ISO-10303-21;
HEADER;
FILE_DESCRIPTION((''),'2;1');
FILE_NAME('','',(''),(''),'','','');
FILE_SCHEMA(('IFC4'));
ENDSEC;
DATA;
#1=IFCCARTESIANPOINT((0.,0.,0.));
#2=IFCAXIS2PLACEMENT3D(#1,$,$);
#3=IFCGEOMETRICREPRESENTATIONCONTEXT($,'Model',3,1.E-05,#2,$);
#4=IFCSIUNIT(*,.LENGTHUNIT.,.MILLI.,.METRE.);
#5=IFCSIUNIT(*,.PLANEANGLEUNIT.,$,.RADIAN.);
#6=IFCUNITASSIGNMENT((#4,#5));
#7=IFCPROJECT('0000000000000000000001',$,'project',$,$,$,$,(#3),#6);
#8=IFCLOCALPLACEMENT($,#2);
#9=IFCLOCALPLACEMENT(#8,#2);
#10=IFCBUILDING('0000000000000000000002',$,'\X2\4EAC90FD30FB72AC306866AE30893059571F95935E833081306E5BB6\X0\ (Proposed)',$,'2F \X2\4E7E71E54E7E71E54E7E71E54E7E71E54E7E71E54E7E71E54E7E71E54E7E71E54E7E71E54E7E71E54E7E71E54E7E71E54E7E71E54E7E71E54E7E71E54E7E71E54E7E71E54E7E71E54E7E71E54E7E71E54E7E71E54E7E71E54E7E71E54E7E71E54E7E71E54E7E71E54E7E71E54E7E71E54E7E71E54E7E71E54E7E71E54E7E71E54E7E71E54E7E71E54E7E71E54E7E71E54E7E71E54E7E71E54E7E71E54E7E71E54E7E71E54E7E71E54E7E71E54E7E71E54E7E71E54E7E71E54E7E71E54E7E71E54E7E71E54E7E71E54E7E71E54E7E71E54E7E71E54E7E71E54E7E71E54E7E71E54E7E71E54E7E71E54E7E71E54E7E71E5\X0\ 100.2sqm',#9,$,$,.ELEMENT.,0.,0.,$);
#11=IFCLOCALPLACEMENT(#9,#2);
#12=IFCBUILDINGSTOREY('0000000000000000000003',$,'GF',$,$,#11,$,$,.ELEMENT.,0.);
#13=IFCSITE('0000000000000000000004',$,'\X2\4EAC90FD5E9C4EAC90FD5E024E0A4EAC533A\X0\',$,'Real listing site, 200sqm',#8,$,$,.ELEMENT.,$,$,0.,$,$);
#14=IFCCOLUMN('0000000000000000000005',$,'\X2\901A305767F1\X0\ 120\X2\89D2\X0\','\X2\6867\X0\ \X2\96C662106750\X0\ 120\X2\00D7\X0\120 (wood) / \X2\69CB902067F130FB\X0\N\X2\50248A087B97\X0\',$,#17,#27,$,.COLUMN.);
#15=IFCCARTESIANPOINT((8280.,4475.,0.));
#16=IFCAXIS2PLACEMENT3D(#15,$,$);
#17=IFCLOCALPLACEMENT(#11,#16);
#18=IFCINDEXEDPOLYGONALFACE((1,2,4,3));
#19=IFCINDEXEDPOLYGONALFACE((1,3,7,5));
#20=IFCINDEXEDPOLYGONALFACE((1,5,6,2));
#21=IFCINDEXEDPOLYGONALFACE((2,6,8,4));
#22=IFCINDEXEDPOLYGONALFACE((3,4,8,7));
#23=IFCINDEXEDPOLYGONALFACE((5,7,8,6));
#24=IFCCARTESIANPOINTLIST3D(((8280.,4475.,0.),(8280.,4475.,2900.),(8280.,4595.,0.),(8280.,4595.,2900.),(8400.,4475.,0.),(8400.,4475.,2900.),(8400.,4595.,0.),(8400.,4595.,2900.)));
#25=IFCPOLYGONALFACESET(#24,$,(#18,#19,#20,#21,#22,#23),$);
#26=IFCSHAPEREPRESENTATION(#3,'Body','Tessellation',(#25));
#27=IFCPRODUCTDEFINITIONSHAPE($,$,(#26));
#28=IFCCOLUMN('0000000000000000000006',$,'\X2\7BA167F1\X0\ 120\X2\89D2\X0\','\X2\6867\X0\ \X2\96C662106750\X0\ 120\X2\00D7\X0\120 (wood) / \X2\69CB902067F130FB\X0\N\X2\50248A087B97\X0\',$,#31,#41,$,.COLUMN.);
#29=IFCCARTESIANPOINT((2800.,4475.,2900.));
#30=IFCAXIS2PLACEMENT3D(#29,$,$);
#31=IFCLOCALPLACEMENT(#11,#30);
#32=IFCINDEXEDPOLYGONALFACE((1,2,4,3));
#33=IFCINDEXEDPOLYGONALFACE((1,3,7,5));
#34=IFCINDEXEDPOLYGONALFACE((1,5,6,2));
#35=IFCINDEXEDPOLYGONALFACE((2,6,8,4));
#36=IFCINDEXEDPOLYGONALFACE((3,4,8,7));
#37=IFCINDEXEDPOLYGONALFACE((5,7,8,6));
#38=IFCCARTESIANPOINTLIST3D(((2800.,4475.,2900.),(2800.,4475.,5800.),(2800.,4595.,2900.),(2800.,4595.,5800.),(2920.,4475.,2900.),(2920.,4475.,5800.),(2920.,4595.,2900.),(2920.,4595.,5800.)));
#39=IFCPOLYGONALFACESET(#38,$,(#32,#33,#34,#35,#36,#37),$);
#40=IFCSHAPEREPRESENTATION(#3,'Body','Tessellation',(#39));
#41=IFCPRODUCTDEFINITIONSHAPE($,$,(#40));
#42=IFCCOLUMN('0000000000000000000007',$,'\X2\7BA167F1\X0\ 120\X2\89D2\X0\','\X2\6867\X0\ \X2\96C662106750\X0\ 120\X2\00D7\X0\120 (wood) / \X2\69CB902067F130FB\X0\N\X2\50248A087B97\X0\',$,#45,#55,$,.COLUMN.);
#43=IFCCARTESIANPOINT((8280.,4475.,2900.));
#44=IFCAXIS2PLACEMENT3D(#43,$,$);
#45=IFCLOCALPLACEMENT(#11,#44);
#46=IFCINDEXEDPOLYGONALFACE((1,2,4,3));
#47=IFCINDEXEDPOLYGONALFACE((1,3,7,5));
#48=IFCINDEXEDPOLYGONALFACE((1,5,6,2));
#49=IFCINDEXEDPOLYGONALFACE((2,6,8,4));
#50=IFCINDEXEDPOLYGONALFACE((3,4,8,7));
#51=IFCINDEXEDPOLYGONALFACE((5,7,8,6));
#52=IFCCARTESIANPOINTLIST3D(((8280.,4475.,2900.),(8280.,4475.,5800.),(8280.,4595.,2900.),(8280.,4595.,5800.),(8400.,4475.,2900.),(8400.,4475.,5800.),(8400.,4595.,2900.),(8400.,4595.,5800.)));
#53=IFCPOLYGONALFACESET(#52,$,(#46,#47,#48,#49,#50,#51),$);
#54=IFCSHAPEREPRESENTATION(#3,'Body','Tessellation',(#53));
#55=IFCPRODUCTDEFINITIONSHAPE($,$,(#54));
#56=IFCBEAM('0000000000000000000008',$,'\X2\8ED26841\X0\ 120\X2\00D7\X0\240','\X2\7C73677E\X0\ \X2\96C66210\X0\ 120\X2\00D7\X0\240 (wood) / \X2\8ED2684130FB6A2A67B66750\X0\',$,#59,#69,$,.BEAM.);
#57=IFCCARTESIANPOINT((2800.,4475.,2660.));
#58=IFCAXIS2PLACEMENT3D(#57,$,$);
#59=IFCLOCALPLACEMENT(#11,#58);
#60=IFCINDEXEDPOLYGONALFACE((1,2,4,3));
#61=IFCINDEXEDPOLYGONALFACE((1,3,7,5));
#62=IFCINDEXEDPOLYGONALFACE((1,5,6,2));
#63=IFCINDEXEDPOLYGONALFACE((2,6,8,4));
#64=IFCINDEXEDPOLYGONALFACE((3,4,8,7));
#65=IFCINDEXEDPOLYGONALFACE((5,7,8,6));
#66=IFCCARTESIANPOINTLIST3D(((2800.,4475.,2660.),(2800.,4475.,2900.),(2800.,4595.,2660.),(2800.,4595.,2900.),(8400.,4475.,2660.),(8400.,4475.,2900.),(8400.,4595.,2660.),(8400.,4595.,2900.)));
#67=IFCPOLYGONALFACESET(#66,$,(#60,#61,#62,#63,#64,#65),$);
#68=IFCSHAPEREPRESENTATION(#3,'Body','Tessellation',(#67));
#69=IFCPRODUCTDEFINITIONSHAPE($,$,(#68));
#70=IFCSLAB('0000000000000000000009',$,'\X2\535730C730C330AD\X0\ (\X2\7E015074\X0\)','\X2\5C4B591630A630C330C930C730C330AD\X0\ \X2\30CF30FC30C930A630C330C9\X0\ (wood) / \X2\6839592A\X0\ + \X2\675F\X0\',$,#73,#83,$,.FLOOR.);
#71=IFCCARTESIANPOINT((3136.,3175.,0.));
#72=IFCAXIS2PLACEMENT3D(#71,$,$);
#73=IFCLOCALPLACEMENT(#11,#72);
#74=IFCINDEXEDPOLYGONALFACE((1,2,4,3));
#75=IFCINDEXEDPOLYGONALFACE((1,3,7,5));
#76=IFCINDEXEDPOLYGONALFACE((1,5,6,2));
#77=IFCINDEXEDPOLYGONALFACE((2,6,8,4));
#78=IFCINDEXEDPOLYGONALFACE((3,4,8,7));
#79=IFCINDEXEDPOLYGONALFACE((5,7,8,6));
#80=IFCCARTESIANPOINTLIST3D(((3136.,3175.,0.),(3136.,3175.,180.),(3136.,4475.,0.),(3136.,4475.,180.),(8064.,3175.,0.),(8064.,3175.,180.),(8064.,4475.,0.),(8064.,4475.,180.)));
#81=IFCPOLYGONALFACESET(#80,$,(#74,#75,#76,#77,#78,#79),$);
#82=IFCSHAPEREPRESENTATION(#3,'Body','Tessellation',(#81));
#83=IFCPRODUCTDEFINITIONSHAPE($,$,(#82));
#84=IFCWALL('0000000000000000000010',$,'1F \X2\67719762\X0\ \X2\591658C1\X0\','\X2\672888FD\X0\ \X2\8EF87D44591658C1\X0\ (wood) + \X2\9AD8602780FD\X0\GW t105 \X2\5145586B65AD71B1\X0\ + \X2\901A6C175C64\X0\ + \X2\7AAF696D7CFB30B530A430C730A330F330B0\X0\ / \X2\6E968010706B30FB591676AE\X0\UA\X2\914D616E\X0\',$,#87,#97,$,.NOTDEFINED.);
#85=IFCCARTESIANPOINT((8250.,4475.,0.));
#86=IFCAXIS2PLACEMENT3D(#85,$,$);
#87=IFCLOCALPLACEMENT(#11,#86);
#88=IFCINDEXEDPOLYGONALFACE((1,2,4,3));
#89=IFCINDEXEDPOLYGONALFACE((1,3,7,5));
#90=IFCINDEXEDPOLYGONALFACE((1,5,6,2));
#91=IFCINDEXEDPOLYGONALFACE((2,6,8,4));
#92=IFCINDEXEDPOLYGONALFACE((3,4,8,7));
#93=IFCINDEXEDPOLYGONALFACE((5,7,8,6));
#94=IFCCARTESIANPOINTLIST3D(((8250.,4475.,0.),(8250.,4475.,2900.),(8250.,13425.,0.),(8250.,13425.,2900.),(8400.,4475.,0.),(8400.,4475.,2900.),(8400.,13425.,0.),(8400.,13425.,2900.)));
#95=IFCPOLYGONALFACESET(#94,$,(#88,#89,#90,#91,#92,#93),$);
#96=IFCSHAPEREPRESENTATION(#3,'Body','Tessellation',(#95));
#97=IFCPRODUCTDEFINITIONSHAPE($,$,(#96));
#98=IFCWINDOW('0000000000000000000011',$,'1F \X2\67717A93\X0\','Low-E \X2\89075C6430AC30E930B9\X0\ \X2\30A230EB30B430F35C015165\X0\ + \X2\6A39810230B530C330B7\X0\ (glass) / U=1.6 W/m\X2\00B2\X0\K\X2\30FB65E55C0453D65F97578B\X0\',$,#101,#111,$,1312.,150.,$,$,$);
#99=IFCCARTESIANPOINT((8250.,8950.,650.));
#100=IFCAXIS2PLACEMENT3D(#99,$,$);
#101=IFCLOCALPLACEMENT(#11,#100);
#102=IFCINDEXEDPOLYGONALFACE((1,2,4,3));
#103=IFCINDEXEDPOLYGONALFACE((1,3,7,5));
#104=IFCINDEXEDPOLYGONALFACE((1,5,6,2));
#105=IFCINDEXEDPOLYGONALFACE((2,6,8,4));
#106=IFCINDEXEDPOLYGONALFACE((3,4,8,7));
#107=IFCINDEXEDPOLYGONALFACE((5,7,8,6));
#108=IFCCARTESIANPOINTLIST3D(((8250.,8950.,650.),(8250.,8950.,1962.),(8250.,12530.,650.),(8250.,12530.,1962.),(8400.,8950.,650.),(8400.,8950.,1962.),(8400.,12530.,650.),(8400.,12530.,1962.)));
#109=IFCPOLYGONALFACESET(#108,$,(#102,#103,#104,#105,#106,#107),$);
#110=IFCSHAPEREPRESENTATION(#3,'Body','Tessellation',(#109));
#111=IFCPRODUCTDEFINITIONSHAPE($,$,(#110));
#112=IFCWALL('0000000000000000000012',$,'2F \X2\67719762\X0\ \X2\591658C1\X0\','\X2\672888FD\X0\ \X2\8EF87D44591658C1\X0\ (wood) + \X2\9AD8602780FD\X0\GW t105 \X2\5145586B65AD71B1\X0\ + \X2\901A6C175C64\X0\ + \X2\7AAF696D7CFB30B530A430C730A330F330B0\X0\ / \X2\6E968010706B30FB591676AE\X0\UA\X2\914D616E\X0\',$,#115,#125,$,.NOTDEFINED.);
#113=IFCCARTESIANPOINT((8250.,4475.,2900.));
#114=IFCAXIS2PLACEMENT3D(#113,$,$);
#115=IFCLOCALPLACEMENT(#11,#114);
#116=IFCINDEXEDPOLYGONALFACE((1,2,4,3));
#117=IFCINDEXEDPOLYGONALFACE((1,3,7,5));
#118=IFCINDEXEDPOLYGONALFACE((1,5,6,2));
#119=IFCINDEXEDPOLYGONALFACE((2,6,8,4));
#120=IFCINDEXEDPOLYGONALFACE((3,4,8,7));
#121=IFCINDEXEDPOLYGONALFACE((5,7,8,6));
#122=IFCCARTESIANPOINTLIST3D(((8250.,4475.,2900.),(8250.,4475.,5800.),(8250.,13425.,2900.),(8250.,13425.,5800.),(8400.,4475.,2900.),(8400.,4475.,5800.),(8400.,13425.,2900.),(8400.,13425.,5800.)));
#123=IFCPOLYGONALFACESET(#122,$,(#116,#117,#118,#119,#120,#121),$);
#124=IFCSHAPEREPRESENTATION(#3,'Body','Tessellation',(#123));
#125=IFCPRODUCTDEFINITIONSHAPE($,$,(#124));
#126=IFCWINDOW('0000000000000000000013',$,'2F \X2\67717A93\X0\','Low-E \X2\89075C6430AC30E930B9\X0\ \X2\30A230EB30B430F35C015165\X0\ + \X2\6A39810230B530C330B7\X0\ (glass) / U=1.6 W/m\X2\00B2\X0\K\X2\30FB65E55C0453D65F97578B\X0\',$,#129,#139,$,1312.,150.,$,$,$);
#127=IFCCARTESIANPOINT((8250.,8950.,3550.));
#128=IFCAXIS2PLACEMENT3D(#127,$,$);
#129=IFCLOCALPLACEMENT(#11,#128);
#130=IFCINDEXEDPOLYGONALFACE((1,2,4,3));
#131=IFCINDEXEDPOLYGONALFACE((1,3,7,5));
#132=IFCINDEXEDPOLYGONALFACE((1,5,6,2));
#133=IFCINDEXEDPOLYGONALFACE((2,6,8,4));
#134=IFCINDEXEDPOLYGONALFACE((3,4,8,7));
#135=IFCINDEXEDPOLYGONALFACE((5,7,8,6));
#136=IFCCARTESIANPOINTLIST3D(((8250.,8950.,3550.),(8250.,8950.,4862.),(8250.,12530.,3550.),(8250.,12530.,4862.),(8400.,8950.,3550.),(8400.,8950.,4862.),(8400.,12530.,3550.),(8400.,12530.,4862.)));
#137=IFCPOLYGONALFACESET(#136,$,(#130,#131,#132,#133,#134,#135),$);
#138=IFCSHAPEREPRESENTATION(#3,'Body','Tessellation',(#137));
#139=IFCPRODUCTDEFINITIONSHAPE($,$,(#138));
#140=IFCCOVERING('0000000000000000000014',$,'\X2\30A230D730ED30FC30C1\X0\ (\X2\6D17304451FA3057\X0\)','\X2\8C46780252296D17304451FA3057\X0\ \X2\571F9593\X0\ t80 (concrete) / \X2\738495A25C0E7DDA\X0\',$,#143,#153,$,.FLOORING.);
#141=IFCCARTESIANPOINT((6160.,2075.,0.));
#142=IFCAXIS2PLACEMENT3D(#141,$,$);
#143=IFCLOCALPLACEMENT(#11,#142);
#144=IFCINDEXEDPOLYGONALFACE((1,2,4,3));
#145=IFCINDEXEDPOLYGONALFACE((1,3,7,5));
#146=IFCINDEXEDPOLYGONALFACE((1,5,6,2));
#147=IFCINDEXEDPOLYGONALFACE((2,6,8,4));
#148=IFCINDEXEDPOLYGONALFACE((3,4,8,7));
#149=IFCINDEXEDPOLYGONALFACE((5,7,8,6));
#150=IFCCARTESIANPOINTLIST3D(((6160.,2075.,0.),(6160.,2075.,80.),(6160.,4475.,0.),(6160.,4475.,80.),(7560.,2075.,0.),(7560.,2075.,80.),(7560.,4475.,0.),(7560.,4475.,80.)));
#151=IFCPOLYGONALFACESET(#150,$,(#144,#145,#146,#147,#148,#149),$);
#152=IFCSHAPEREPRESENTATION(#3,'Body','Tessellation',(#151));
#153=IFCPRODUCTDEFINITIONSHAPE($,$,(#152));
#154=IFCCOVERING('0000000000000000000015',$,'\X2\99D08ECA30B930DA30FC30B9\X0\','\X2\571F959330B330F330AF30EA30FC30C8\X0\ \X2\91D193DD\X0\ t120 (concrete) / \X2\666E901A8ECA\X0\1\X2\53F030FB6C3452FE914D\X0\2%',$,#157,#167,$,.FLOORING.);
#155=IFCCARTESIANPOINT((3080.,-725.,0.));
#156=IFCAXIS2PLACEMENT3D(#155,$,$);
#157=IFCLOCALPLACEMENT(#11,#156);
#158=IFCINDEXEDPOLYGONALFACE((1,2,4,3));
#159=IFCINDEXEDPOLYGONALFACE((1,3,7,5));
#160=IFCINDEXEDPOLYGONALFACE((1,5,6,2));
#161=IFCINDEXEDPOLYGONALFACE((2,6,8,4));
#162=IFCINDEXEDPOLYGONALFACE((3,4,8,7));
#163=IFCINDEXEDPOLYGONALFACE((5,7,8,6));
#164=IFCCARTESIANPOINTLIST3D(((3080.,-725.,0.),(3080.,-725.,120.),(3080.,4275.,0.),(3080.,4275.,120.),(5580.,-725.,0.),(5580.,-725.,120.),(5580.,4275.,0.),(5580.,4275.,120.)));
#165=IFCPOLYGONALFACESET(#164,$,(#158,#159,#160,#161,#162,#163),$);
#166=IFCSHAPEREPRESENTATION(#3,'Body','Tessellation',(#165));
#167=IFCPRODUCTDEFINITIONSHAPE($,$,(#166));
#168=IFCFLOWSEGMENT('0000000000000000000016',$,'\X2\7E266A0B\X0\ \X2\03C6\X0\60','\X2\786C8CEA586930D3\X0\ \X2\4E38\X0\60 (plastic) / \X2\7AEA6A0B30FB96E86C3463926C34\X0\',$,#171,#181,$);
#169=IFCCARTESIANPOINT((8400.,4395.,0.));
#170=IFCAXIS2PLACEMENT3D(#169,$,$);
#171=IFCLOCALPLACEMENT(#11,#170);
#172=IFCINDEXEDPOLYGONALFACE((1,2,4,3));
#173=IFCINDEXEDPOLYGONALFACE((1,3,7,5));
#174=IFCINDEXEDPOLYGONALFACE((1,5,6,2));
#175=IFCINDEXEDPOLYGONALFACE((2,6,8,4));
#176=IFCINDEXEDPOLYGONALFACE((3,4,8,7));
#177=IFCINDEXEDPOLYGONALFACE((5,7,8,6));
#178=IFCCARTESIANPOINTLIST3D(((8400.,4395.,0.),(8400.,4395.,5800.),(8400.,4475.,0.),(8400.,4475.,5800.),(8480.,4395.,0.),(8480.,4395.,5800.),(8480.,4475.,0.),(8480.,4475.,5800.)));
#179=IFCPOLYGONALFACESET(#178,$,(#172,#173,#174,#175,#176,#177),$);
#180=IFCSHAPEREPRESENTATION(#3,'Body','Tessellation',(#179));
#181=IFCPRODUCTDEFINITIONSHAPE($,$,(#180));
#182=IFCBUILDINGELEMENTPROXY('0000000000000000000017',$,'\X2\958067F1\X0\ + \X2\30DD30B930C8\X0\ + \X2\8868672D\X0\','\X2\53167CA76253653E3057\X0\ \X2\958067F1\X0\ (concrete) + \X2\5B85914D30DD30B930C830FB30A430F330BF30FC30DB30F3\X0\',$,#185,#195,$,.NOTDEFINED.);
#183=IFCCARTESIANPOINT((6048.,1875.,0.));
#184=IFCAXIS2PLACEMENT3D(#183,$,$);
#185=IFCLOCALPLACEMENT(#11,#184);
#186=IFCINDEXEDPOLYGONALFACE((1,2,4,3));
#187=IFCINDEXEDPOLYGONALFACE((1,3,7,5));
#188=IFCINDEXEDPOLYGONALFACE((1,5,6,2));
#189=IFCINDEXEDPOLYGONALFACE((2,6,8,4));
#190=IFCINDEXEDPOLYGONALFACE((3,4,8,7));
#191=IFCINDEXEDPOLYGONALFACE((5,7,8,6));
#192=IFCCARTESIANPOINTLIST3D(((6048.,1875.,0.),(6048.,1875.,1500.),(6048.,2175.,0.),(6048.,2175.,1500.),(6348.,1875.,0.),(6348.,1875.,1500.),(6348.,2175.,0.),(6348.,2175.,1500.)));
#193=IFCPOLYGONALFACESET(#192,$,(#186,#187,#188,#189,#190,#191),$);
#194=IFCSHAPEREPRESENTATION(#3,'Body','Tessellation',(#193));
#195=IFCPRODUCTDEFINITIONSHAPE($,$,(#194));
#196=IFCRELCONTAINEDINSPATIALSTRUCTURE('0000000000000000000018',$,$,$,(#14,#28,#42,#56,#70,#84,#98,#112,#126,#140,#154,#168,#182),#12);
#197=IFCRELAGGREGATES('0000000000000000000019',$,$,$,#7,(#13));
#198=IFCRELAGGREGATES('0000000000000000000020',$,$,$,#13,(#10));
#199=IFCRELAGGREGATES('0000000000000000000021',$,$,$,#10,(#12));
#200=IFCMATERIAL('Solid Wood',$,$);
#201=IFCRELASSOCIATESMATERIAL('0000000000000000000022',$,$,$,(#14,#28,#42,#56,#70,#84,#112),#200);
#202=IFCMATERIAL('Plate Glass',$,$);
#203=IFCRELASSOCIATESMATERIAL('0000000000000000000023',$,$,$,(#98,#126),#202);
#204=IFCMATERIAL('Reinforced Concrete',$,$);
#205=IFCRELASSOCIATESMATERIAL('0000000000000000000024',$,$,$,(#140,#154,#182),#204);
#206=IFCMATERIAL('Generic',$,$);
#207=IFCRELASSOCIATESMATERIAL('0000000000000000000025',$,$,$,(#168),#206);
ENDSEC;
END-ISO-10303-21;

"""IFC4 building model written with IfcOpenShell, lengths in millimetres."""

from ifc_helpers import new_model, si_unit, frame, frame_2d, origin, place, context, project, spatial, rectangle, extrude, material, element, fill, save


model = new_model("IFC4")

# Units and contexts
model_context = context("Model", 3, precision=1e-05, world=origin())
ifc_project = project(units=[si_unit("LENGTHUNIT", "METRE", prefix="MILLI"), si_unit("PLANEANGLEUNIT", "RADIAN")], contexts=[model_context])

# Site, building, storey
site_placement = place(None, origin())
site = spatial("IfcSite", under=ifc_project, at=site_placement, Name="京都府京都市上京区", ObjectType="Real listing site, 200sqm", CompositionType="ELEMENT", RefElevation=0.0)
building_placement = place(site_placement, origin())
building = spatial("IfcBuilding", under=site, at=building_placement, Name="京都・犬と暮らす土間広めの家 (Proposed)", ObjectType="2F 乾燥乾燥乾燥乾燥乾燥乾燥乾燥乾燥乾燥乾燥乾燥乾燥乾燥乾燥乾燥乾燥乾燥乾燥乾燥乾燥乾燥乾燥乾燥乾燥乾燥乾燥乾燥乾燥乾燥乾燥乾燥乾燥乾燥乾燥乾燥乾燥乾燥乾燥乾燥乾燥乾燥乾燥乾燥乾燥乾燥乾燥乾燥乾燥乾燥乾燥乾燥乾燥乾燥乾燥乾燥乾燥乾燥乾燥乾燥乾燥 100.2sqm", CompositionType="ELEMENT", ElevationOfRefHeight=0.0, ElevationOfTerrain=0.0)
storey_placement = place(building_placement, origin())
storey = spatial("IfcBuildingStorey", under=building, at=storey_placement, Name="GF", CompositionType="ELEMENT", Elevation=0.0)

# Columns
ifc_material_1 = material(Name="Solid Wood")
column_1_placement = place(storey_placement, frame((8280.0, 4475.0, 0.0)))
element("IfcColumn", 1, at=column_1_placement, inside=storey, material=ifc_material_1, Name="通し柱 120角", Description="桧 集成材 120×120 (wood) / 構造柱・N値計算", PredefinedType="COLUMN", context=model_context, shape_type="SweptSolid", body=[
    extrude(rectangle(XDim=120.0, YDim=120.0, at=frame_2d((60.0, 60.0))), frame((8280.0, 4475.0, 0.0)), (0.0, 0.0, 1.0), 2900.0),
])
column_2_placement = place(storey_placement, frame((2800.0, 4475.0, 2900.0)))
element("IfcColumn", 2, at=column_2_placement, inside=storey, material=ifc_material_1, Name="管柱 120角", Description="桧 集成材 120×120 (wood) / 構造柱・N値計算", PredefinedType="COLUMN", context=model_context, shape_type="SweptSolid", body=[
    extrude(rectangle(XDim=120.0, YDim=120.0, at=frame_2d((60.0, 60.0))), frame((2800.0, 4475.0, 2900.0)), (0.0, 0.0, 1.0), 2900.0),
])
column_3_placement = place(storey_placement, frame((8280.0, 4475.0, 2900.0)))
element("IfcColumn", 3, at=column_3_placement, inside=storey, material=ifc_material_1, Name="管柱 120角", Description="桧 集成材 120×120 (wood) / 構造柱・N値計算", PredefinedType="COLUMN", context=model_context, shape_type="SweptSolid", body=[
    extrude(rectangle(XDim=120.0, YDim=120.0, at=frame_2d((60.0, 60.0))), frame((8280.0, 4475.0, 2900.0)), (0.0, 0.0, 1.0), 2900.0),
])

# Beam
beam_1_placement = place(storey_placement, frame((2800.0, 4475.0, 2660.0)))
element("IfcBeam", 4, at=beam_1_placement, inside=storey, material=ifc_material_1, Name="軒桁 120×240", Description="米松 集成 120×240 (wood) / 軒桁・横架材", PredefinedType="BEAM", context=model_context, shape_type="SweptSolid", body=[
    extrude(rectangle(XDim=5600.0, YDim=120.0, at=frame_2d((2800.0, 60.0))), frame((2800.0, 4475.0, 2660.0)), (0.0, 0.0, 1.0), 240.0),
])

# Slab
slab_placement = place(storey_placement, frame((3136.0, 3175.0, 0.0)))
element("IfcSlab", 5, at=slab_placement, inside=storey, material=ifc_material_1, Name="南デッキ (縁側)", Description="屋外ウッドデッキ ハードウッド (wood) / 根太 + 束", PredefinedType="FLOOR", context=model_context, shape_type="SweptSolid", body=[
    extrude(rectangle(XDim=4928.0, YDim=1300.0, at=frame_2d((2464.0, 650.0))), frame((3136.0, 3175.0, 0.0)), (0.0, 0.0, 1.0), 180.0),
])

# Walls, openings, windows
wall_1_placement = place(storey_placement, frame((8250.0, 4475.0, 0.0)))
wall_1 = element("IfcWall", 6, at=wall_1_placement, inside=storey, material=ifc_material_1, Name="1F 東面 外壁", Description="木製 軸組外壁 (wood) + 高性能GW t105 充填断熱 + 通気層 + 窯業系サイディング / 準耐火・外皮UA配慮", PredefinedType="NOTDEFINED", context=model_context, shape_type="SweptSolid", body=[
    extrude(rectangle(XDim=150.0, YDim=8950.0, at=frame_2d((75.0, 4475.0))), frame((8250.0, 4475.0, 0.0)), (0.0, 0.0, 1.0), 2900.0),
])
opening_1_placement = place(storey_placement, frame((8250.0, 8950.0, 650.0)))
opening_1 = element("IfcOpeningElement", 7, at=opening_1_placement, cuts=wall_1, PredefinedType="NOTDEFINED", context=model_context, shape_type="SweptSolid", body=[
    extrude(rectangle(XDim=150.0, YDim=3580.0, at=frame_2d((75.0, 1790.0))), frame((8250.0, 8950.0, 650.0)), (0.0, 0.0, 1.0), 1312.0),
])
ifc_material_2 = material(Name="Plate Glass")
window_1_placement = place(storey_placement, frame((8250.0, 8950.0, 650.0)))
window_1 = element("IfcWindow", 8, at=window_1_placement, inside=storey, material=ifc_material_2, Name="1F 東窓", Description="Low-E 複層ガラス アルゴン封入 + 樹脂サッシ (glass) / U=1.6 W/m²K・日射取得型", OverallHeight=1312.0, OverallWidth=150.0, context=model_context, shape_type="SweptSolid", body=[
    extrude(rectangle(XDim=150.0, YDim=3580.0, at=frame_2d((75.0, 1790.0))), frame((8250.0, 8950.0, 650.0)), (0.0, 0.0, 1.0), 1312.0),
])
fill(opening_1, window_1)
wall_2_placement = place(storey_placement, frame((8250.0, 4475.0, 2900.0)))
wall_2 = element("IfcWall", 9, at=wall_2_placement, inside=storey, material=ifc_material_1, Name="2F 東面 外壁", Description="木製 軸組外壁 (wood) + 高性能GW t105 充填断熱 + 通気層 + 窯業系サイディング / 準耐火・外皮UA配慮", PredefinedType="NOTDEFINED", context=model_context, shape_type="SweptSolid", body=[
    extrude(rectangle(XDim=150.0, YDim=8950.0, at=frame_2d((75.0, 4475.0))), frame((8250.0, 4475.0, 2900.0)), (0.0, 0.0, 1.0), 2900.0),
])
opening_2_placement = place(storey_placement, frame((8250.0, 8950.0, 3550.0)))
opening_2 = element("IfcOpeningElement", 10, at=opening_2_placement, cuts=wall_2, PredefinedType="NOTDEFINED", context=model_context, shape_type="SweptSolid", body=[
    extrude(rectangle(XDim=150.0, YDim=3580.0, at=frame_2d((75.0, 1790.0))), frame((8250.0, 8950.0, 3550.0)), (0.0, 0.0, 1.0), 1312.0),
])
window_2_placement = place(storey_placement, frame((8250.0, 8950.0, 3550.0)))
window_2 = element("IfcWindow", 11, at=window_2_placement, inside=storey, material=ifc_material_2, Name="2F 東窓", Description="Low-E 複層ガラス アルゴン封入 + 樹脂サッシ (glass) / U=1.6 W/m²K・日射取得型", OverallHeight=1312.0, OverallWidth=150.0, context=model_context, shape_type="SweptSolid", body=[
    extrude(rectangle(XDim=150.0, YDim=3580.0, at=frame_2d((75.0, 1790.0))), frame((8250.0, 8950.0, 3550.0)), (0.0, 0.0, 1.0), 1312.0),
])
fill(opening_2, window_2)

# Coverings
ifc_material_3 = material(Name="Reinforced Concrete")
covering_1_placement = place(storey_placement, frame((6160.0, 2075.0, 0.0)))
element("IfcCovering", 12, at=covering_1_placement, inside=storey, material=ifc_material_3, Name="アプローチ (洗い出し)", Description="豆砂利洗い出し 土間 t80 (concrete) / 玄関導線", PredefinedType="FLOORING", context=model_context, shape_type="SweptSolid", body=[
    extrude(rectangle(XDim=1400.0, YDim=2400.0, at=frame_2d((700.0, 1200.0))), frame((6160.0, 2075.0, 0.0)), (0.0, 0.0, 1.0), 80.0),
])
covering_2_placement = place(storey_placement, frame((3080.0, -725.0, 0.0)))
element("IfcCovering", 13, at=covering_2_placement, inside=storey, material=ifc_material_3, Name="駐車スペース", Description="土間コンクリート 金鏝 t120 (concrete) / 普通車1台・水勾配2%", PredefinedType="FLOORING", context=model_context, shape_type="SweptSolid", body=[
    extrude(rectangle(XDim=2500.0, YDim=5000.0, at=frame_2d((1250.0, 2500.0))), frame((3080.0, -725.0, 0.0)), (0.0, 0.0, 1.0), 120.0),
])

# Flow segment
ifc_material_4 = material(Name="Generic")
flow_segment_placement = place(storey_placement, frame((8400.0, 4395.0, 0.0)))
element("IfcFlowSegment", 14, at=flow_segment_placement, inside=storey, material=ifc_material_4, Name="縦樋 φ60", Description="硬質塩ビ 丸60 (plastic) / 竪樋・雨水排水", context=model_context, shape_type="SweptSolid", body=[
    extrude(rectangle(XDim=80.0, YDim=80.0, at=frame_2d((40.0, 40.0))), frame((8400.0, 4395.0, 0.0)), (0.0, 0.0, 1.0), 5800.0),
])

# Building element proxy
proxy_placement = place(storey_placement, frame((6048.0, 1875.0, 0.0)))
element("IfcBuildingElementProxy", 15, at=proxy_placement, inside=storey, material=ifc_material_3, Name="門柱 + ポスト + 表札", Description="化粧打放し 門柱 (concrete) + 宅配ポスト・インターホン", PredefinedType="NOTDEFINED", context=model_context, shape_type="SweptSolid", body=[
    extrude(rectangle(XDim=300.0, YDim=300.0, at=frame_2d((150.0, 150.0))), frame((6048.0, 1875.0, 0.0)), (0.0, 0.0, 1.0), 1500.0),
])

save(model, "model.ifc")
